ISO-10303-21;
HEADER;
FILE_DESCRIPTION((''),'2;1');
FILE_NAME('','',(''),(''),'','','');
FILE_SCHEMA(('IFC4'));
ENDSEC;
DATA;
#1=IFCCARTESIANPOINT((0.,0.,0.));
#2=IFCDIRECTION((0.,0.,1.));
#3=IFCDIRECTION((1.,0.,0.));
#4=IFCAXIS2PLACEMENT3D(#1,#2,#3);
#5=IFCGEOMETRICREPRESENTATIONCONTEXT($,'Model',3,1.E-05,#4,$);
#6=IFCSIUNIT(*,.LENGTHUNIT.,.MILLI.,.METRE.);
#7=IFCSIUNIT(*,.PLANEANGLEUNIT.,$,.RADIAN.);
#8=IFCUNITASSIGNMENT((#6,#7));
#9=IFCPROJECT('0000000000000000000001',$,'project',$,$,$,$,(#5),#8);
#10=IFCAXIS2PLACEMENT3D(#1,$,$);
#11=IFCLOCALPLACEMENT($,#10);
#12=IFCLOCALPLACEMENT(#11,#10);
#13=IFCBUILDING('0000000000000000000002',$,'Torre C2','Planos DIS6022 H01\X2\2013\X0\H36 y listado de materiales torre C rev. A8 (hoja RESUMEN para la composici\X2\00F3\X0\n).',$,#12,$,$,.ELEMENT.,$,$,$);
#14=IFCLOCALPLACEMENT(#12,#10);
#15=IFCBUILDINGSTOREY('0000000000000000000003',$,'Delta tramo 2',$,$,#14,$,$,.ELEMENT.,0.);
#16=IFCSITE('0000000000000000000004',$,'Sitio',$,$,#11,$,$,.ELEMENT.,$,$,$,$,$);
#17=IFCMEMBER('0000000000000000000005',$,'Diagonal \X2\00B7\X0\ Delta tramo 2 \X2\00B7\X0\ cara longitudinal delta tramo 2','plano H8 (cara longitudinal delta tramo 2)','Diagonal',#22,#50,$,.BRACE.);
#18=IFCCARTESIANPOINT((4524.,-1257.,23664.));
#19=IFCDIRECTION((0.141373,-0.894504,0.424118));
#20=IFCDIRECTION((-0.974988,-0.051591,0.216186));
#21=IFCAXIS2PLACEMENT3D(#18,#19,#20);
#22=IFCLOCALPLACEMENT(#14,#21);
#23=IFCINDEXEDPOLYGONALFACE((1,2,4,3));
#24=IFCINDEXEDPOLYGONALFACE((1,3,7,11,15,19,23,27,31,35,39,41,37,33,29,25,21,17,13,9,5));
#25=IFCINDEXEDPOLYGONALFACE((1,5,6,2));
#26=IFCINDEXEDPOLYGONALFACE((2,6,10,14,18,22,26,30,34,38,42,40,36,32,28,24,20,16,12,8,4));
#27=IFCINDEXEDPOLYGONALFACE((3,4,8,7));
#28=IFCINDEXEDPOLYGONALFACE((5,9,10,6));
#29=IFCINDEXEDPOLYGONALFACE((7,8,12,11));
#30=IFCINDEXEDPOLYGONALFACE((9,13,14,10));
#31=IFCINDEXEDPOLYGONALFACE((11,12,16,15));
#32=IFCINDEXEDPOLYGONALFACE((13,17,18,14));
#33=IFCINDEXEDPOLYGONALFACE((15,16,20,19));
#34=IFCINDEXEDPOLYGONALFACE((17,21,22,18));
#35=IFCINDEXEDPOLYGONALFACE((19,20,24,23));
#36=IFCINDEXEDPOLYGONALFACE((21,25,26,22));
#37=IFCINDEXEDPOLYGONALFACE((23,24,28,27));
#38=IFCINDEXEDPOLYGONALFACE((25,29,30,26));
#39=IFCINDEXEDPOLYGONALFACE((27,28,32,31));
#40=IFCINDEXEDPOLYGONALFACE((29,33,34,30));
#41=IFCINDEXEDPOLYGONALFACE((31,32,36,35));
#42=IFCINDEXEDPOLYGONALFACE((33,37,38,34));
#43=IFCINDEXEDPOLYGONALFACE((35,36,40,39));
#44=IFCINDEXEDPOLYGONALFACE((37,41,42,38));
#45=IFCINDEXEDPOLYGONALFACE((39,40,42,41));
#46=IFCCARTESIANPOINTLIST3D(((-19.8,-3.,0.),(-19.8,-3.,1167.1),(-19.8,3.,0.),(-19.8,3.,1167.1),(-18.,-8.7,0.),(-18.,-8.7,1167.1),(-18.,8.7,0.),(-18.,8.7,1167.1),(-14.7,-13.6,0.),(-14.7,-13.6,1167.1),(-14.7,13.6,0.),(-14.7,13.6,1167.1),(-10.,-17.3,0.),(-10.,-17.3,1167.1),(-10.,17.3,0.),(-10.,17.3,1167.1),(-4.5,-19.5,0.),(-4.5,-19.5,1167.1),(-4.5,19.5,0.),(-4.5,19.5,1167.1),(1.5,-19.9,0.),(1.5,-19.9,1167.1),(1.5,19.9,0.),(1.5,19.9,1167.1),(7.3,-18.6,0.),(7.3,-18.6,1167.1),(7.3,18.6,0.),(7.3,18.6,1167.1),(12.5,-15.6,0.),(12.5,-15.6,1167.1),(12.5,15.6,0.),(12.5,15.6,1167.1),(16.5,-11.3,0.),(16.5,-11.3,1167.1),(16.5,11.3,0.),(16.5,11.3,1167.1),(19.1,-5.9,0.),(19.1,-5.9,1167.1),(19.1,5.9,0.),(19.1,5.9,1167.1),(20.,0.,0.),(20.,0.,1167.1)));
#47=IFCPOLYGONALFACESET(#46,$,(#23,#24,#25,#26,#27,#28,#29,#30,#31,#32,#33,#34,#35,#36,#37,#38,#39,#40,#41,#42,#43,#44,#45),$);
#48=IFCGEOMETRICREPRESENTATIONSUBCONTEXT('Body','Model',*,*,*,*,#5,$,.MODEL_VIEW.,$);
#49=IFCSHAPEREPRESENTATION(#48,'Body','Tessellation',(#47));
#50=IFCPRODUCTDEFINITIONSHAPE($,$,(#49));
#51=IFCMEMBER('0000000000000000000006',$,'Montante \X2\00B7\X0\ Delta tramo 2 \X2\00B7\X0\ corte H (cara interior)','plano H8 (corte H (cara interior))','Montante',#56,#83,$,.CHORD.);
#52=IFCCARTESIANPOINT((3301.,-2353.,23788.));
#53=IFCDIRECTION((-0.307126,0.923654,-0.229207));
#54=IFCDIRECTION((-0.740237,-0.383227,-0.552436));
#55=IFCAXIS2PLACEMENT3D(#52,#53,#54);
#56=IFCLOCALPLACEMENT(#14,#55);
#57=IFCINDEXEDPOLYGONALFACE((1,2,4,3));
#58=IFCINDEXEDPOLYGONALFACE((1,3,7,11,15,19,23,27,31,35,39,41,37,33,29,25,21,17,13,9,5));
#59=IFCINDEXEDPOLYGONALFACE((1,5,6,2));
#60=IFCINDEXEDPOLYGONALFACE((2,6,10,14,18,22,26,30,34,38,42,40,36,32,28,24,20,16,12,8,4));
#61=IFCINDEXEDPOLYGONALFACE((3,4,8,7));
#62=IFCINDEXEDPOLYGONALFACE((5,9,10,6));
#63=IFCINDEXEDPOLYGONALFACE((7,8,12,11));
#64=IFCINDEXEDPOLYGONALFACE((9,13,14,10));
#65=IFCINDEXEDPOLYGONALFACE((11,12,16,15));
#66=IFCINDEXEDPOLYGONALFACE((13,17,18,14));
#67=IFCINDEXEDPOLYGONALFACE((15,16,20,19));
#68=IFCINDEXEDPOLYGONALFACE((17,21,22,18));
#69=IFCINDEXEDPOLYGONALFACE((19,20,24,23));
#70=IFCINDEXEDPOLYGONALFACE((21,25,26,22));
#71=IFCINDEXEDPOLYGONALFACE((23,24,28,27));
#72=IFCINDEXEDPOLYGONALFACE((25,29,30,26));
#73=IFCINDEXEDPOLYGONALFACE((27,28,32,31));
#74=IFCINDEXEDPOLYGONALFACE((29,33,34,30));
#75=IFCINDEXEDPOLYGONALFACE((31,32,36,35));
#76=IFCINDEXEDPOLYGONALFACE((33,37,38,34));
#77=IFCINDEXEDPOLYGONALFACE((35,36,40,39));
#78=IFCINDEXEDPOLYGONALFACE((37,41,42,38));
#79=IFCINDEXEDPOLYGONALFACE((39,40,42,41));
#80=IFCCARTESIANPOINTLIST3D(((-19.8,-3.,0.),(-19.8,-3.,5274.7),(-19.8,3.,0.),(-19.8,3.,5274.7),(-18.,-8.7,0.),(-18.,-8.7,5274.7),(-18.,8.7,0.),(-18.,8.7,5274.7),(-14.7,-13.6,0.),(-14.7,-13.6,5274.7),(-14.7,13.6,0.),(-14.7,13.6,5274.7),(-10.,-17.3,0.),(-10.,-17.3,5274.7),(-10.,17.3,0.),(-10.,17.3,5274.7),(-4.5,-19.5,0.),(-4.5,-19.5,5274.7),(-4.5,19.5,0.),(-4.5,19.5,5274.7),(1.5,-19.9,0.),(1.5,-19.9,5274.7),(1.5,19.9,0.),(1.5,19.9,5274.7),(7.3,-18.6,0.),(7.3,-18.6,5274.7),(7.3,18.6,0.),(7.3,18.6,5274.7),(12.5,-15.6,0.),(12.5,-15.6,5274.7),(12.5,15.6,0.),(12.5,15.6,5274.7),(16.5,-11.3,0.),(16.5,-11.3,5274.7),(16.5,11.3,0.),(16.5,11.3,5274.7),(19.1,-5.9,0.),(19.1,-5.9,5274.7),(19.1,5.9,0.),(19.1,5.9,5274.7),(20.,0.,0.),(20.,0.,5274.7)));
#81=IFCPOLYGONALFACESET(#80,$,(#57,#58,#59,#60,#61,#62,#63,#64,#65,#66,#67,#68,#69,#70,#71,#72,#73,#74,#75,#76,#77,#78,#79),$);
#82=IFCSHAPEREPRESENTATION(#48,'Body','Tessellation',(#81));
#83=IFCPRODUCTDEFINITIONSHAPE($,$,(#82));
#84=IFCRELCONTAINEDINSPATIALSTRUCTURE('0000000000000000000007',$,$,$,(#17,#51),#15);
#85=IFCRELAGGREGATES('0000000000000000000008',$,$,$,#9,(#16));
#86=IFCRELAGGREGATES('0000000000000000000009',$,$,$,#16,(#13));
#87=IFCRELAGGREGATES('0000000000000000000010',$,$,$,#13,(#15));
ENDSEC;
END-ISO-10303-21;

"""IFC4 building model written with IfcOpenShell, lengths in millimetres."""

from ifc_helpers import new_model, si_unit, frame, origin, origin_with_axes, place, context, subcontext, project, spatial, circle, extrude, element, save


model = new_model("IFC4")

# Units and contexts
model_context = context("Model", 3, precision=1e-05, world=origin_with_axes())
body_context = subcontext(model_context, "Body", "Model", "MODEL_VIEW")
ifc_project = project(units=[si_unit("LENGTHUNIT", "METRE", prefix="MILLI"), si_unit("PLANEANGLEUNIT", "RADIAN")], contexts=[model_context])

# Site, building, storey
site_placement = place(None, origin())
site = spatial("IfcSite", under=ifc_project, at=site_placement, Name="Sitio", CompositionType="ELEMENT")
building_placement = place(site_placement, origin())
building = spatial("IfcBuilding", under=site, at=building_placement, Name="Torre C2", Description="Planos DIS6022 H01–H36 y listado de materiales torre C rev. A8 (hoja RESUMEN para la composición).", CompositionType="ELEMENT")
storey_placement = place(building_placement, origin())
storey = spatial("IfcBuildingStorey", under=building, at=storey_placement, Name="Delta tramo 2", CompositionType="ELEMENT", Elevation=0.0)

# Members
member_1_placement = place(storey_placement, frame((4524.0, -1257.0, 23664.0), z_axis=(0.141373, -0.894504, 0.424118), x_axis=(-0.974988, -0.051591, 0.216186)))
element("IfcMember", 1, at=member_1_placement, inside=storey, Name="Diagonal · Delta tramo 2 · cara longitudinal delta tramo 2", Description="plano H8 (cara longitudinal delta tramo 2)", ObjectType="Diagonal", PredefinedType="BRACE", context=body_context, shape_type="SweptSolid", body=[
    extrude(circle(Radius=20.0), None, (0.0, 0.0, 1.0), 1167.1),
])
member_2_placement = place(storey_placement, frame((3301.0, -2353.0, 23788.0), z_axis=(-0.307126, 0.923654, -0.229207), x_axis=(-0.740237, -0.383227, -0.552436)))
element("IfcMember", 2, at=member_2_placement, inside=storey, Name="Montante · Delta tramo 2 · corte H (cara interior)", Description="plano H8 (corte H (cara interior))", ObjectType="Montante", PredefinedType="CHORD", context=body_context, shape_type="SweptSolid", body=[
    extrude(circle(Radius=20.0), None, (0.0, 0.0, 1.0), 5274.7),
])

save(model, "model.ifc")
